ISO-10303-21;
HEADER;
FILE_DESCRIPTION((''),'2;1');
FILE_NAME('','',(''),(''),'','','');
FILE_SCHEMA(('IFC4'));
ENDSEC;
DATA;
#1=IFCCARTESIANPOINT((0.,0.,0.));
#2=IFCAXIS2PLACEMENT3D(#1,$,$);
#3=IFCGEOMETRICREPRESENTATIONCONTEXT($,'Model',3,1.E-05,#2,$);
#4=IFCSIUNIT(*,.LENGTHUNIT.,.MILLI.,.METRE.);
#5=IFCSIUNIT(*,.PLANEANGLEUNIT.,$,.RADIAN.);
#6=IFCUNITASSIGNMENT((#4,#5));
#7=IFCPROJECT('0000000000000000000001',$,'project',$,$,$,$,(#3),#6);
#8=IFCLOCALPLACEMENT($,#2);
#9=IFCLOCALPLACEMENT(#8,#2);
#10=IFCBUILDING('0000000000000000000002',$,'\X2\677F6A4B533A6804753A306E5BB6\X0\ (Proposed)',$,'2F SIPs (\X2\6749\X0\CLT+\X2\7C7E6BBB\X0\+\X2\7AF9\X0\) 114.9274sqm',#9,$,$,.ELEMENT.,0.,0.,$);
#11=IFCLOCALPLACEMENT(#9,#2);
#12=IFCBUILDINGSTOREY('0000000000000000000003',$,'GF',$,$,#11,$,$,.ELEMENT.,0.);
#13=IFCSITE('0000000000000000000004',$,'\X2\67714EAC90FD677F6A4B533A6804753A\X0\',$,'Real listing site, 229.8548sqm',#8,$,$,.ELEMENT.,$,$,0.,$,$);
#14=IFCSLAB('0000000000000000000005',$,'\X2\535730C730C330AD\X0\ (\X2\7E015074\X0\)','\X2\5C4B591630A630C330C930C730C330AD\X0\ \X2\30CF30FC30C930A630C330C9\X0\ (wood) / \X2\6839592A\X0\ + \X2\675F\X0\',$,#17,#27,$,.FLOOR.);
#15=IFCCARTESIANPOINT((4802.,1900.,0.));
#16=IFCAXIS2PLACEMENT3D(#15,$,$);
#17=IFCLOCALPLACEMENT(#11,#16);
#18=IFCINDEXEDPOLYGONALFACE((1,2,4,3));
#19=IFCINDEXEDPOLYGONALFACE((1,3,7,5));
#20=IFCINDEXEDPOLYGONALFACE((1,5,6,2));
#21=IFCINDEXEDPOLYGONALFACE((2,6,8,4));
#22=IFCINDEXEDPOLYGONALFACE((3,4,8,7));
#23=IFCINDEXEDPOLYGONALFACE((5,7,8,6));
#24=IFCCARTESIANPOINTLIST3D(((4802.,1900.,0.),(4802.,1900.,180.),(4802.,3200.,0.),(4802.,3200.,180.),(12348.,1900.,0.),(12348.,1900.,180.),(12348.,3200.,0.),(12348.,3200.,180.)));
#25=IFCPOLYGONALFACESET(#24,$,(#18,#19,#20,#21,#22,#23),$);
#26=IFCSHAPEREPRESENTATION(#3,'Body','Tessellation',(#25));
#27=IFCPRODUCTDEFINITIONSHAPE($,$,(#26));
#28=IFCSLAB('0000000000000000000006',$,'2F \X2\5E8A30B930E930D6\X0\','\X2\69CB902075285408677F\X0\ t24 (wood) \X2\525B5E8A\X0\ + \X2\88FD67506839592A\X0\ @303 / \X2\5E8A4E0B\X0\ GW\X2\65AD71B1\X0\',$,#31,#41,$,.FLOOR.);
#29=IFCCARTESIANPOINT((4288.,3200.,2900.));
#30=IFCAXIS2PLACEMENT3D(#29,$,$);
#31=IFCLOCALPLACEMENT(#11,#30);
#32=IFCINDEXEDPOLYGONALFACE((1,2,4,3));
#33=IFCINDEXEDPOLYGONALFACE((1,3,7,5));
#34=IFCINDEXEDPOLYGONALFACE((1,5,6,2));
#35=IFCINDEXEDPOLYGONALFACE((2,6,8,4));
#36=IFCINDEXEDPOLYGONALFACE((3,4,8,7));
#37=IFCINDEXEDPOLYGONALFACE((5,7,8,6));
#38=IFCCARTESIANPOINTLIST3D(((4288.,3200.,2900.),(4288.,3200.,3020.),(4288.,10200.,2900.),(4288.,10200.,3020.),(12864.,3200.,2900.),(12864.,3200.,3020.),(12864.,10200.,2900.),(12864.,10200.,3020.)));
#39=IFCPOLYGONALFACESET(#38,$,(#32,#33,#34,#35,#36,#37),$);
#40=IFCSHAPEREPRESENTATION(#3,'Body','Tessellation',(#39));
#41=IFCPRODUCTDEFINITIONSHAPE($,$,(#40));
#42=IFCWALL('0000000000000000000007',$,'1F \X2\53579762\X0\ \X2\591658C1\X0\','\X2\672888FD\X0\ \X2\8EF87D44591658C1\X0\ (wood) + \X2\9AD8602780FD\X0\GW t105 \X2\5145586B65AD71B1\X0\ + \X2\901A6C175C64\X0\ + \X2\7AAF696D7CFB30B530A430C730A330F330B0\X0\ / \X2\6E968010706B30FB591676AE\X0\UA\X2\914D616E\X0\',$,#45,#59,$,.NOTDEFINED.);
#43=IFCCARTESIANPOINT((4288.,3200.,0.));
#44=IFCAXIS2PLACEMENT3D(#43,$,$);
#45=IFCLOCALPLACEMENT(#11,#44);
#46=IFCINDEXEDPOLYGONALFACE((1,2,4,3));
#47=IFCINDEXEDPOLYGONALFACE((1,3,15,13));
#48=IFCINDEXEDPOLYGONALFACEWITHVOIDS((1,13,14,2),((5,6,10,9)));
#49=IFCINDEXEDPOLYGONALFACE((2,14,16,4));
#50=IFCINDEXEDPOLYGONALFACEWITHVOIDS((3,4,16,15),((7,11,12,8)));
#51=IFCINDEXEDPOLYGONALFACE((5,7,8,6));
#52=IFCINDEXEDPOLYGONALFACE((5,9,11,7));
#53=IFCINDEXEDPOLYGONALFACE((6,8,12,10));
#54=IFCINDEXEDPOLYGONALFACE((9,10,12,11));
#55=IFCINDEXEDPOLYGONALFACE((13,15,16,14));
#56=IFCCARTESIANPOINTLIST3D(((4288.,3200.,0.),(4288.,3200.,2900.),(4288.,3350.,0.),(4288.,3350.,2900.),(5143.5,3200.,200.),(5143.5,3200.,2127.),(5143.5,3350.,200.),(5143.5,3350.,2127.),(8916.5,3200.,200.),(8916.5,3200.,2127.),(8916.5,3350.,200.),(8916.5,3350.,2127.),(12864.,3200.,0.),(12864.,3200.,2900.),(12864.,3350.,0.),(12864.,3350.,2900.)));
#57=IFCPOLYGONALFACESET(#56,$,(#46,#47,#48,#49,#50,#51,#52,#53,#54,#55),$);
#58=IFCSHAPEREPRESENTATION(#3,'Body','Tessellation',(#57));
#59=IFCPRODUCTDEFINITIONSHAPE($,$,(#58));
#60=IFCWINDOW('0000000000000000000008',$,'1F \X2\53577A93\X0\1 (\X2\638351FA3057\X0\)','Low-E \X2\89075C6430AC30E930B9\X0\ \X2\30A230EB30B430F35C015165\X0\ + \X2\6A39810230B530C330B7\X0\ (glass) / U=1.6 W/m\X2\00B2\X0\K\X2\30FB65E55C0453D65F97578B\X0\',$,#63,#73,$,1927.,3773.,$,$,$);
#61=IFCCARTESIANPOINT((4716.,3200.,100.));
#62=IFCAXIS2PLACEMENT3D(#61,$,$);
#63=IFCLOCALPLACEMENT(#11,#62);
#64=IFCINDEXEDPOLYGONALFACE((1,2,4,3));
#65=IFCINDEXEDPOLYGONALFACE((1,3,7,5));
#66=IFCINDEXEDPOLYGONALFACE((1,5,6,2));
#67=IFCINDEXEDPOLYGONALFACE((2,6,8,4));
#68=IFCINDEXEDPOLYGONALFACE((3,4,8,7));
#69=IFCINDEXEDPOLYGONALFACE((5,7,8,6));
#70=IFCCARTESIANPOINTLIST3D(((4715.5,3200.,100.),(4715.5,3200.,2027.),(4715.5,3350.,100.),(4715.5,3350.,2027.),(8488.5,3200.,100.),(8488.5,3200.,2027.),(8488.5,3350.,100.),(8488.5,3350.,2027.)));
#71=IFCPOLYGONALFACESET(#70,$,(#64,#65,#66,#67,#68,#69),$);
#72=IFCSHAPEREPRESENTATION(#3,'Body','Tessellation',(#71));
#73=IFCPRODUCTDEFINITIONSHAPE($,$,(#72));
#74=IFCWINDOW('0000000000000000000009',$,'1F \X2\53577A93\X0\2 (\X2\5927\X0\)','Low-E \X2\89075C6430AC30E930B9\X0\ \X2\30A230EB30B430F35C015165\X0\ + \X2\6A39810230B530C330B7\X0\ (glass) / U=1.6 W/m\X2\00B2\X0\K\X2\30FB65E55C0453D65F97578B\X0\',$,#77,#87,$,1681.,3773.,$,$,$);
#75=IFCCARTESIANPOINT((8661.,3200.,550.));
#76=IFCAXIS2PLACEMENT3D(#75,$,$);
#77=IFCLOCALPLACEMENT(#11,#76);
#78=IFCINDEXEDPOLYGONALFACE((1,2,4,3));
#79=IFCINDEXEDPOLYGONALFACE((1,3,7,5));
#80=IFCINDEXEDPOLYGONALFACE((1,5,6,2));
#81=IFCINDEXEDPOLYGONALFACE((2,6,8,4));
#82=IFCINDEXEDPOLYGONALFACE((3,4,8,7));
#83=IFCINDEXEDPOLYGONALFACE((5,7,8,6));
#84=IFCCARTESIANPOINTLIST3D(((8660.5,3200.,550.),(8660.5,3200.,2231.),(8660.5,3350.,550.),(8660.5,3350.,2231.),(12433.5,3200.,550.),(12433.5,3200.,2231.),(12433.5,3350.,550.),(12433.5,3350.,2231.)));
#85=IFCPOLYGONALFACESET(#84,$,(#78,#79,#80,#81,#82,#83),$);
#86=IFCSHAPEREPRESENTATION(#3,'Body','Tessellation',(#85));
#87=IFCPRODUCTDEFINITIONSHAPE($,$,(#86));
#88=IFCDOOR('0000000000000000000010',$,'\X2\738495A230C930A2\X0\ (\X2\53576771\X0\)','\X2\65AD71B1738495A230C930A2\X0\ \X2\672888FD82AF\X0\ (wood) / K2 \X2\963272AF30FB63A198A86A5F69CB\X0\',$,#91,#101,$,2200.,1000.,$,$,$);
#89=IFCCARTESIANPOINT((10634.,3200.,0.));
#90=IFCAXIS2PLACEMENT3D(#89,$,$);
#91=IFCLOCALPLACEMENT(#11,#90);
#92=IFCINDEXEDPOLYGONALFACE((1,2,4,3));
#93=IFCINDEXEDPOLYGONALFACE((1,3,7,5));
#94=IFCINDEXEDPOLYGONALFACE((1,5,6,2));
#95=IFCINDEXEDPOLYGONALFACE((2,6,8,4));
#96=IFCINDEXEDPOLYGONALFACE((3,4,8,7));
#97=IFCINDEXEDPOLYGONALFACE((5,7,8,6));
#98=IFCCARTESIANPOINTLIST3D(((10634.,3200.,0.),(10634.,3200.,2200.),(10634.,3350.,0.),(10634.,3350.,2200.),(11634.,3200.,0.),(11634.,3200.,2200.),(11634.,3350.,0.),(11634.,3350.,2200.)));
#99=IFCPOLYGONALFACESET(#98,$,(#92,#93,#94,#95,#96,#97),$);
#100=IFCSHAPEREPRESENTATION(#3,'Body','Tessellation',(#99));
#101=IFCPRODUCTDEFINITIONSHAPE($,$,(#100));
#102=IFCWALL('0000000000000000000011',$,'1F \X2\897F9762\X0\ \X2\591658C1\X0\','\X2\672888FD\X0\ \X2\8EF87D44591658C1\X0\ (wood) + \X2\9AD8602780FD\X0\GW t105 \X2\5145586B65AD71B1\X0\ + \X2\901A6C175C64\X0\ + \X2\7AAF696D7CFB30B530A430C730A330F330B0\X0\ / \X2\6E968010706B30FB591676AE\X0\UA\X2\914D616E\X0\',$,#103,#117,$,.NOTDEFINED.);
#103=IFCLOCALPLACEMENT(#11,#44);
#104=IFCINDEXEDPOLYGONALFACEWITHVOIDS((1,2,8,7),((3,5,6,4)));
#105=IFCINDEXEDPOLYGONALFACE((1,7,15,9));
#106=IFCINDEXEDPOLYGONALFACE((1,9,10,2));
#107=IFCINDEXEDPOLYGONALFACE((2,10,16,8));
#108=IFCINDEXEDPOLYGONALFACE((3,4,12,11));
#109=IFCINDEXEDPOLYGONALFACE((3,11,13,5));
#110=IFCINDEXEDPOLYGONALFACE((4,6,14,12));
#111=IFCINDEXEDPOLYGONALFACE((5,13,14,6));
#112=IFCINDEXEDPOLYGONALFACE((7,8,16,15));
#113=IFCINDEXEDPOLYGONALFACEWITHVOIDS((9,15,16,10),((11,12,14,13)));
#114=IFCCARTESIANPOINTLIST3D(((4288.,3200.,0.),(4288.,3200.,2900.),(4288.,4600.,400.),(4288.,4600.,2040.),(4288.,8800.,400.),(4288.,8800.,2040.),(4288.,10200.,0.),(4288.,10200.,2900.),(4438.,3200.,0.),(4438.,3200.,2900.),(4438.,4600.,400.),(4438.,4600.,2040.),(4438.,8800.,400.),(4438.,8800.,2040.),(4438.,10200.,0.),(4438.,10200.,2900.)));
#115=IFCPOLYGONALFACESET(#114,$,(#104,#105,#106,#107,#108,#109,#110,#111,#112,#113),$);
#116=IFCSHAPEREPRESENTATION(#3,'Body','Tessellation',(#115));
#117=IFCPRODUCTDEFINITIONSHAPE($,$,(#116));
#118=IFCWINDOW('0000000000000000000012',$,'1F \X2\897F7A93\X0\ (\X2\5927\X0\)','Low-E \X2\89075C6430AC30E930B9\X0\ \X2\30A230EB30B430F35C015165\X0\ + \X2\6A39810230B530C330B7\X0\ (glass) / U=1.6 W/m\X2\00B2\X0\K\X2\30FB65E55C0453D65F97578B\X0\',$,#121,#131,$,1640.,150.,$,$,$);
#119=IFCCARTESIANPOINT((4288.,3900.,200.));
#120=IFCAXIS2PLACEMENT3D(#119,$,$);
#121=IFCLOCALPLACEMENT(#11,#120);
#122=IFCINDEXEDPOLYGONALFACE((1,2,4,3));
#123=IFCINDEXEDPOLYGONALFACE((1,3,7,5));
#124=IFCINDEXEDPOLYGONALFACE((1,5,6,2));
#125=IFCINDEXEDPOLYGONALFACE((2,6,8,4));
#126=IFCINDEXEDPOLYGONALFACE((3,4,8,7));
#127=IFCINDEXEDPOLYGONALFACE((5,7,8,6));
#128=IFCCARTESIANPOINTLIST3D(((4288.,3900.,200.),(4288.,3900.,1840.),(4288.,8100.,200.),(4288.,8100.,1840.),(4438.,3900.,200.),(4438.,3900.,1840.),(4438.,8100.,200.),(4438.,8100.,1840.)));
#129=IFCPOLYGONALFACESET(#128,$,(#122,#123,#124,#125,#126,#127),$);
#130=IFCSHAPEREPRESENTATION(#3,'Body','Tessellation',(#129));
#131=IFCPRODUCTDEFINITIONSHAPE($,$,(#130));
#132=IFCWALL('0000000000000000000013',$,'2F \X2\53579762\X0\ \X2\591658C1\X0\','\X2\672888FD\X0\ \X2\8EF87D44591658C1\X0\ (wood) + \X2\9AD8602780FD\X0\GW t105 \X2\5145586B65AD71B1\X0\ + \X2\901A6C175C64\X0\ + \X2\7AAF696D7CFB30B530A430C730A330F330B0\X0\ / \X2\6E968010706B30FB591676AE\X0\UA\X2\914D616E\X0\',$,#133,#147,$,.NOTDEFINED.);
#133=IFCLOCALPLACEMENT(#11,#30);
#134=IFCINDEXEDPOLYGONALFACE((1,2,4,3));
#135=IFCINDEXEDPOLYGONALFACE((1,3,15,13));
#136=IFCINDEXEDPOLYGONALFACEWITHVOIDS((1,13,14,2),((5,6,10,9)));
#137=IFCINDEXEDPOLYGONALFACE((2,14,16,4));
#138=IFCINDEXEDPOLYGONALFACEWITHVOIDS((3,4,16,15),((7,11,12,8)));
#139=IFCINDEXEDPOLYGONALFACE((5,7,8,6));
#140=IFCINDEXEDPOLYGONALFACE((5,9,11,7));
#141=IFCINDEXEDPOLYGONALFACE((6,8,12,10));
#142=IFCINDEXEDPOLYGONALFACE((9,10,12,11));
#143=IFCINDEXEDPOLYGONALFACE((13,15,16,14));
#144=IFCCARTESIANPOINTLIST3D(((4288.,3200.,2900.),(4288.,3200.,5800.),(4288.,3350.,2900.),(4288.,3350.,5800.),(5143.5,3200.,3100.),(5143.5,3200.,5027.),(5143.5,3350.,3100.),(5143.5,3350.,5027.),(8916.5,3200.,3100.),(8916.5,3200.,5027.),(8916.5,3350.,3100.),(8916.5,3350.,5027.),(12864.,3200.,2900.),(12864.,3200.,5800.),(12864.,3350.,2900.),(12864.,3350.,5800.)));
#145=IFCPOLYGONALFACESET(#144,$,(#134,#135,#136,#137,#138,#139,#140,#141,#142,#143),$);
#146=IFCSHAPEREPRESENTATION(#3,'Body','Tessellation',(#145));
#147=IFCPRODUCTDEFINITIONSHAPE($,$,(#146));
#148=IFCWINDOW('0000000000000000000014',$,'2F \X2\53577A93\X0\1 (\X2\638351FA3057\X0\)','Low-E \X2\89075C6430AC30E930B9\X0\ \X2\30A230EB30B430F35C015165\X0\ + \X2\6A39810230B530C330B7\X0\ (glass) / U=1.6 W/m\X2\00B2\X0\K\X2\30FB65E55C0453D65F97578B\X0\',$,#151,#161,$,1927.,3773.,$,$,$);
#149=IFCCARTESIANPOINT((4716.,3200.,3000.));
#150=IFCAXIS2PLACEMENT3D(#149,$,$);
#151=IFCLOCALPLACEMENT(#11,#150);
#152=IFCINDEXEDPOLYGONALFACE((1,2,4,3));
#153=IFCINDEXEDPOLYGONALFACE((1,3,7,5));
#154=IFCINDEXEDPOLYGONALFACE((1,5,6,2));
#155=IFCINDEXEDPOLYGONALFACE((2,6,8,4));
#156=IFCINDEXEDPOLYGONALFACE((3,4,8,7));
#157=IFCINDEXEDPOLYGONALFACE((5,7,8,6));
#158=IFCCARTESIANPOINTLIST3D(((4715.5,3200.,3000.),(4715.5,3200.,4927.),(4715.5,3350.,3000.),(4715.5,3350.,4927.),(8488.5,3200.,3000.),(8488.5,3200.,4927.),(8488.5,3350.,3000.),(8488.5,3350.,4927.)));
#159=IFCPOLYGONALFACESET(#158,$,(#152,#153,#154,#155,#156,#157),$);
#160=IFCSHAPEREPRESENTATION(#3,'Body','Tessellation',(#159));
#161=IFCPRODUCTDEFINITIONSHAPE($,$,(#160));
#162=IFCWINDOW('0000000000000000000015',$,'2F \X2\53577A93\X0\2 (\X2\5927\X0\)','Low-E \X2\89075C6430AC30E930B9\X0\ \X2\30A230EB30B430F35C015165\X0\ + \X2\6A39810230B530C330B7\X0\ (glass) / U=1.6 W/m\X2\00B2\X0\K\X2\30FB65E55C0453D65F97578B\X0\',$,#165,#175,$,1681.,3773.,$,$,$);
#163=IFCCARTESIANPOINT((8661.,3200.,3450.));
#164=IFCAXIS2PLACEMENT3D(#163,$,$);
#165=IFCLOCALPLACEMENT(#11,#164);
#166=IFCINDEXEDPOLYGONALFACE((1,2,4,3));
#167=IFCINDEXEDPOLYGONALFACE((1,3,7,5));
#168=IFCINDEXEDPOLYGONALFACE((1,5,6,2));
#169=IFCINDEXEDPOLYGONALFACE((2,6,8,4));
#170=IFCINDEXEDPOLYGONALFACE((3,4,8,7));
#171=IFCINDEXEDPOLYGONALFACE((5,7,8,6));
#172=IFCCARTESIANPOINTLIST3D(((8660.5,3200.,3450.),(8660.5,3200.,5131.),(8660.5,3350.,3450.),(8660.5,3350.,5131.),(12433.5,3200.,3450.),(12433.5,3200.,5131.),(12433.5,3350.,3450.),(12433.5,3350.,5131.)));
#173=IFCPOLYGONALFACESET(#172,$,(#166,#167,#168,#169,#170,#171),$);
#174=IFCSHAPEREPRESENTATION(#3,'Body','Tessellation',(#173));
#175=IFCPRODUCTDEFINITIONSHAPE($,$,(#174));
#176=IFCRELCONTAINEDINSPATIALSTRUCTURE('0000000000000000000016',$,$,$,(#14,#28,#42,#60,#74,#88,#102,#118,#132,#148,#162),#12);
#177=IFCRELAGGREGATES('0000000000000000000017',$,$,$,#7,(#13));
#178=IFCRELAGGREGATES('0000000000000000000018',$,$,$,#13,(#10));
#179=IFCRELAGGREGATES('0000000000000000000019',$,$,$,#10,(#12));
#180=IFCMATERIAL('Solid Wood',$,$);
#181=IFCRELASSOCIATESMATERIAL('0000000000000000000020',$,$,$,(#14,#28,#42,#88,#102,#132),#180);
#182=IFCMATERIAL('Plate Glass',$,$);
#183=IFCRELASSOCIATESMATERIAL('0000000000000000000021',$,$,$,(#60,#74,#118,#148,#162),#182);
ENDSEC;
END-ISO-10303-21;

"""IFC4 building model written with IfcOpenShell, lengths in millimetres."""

from ifc_helpers import new_model, si_unit, frame, frame_2d, origin, place, context, project, spatial, rectangle, extrude, material, element, fill, save


model = new_model("IFC4")

# Units and contexts
model_context = context("Model", 3, precision=1e-05, world=origin())
ifc_project = project(units=[si_unit("LENGTHUNIT", "METRE", prefix="MILLI"), si_unit("PLANEANGLEUNIT", "RADIAN")], contexts=[model_context])

# Site, building, storey
site_placement = place(None, origin())
site = spatial("IfcSite", under=ifc_project, at=site_placement, Name="東京都板橋区栄町", ObjectType="Real listing site, 229.8548sqm", CompositionType="ELEMENT", RefElevation=0.0)
building_placement = place(site_placement, origin())
building = spatial("IfcBuilding", under=site, at=building_placement, Name="板橋区栄町の家 (Proposed)", ObjectType="2F SIPs (杉CLT+籾殻+竹) 114.9274sqm", CompositionType="ELEMENT", ElevationOfRefHeight=0.0, ElevationOfTerrain=0.0)
storey_placement = place(building_placement, origin())
storey = spatial("IfcBuildingStorey", under=building, at=storey_placement, Name="GF", CompositionType="ELEMENT", Elevation=0.0)

# Slabs
ifc_material_1 = material(Name="Solid Wood")
slab_1_placement = place(storey_placement, frame((4802.0, 1900.0, 0.0)))
element("IfcSlab", 1, at=slab_1_placement, inside=storey, material=ifc_material_1, Name="南デッキ (縁側)", Description="屋外ウッドデッキ ハードウッド (wood) / 根太 + 束", PredefinedType="FLOOR", context=model_context, shape_type="SweptSolid", body=[
    extrude(rectangle(XDim=7546.0, YDim=1300.0, at=frame_2d((3773.0, 650.0))), frame((4802.0, 1900.0, 0.0)), (0.0, 0.0, 1.0), 180.0),
])
slab_2_placement = place(storey_placement, frame((4288.0, 3200.0, 2900.0)))
element("IfcSlab", 2, at=slab_2_placement, inside=storey, material=ifc_material_1, Name="2F 床スラブ", Description="構造用合板 t24 (wood) 剛床 + 製材根太 @303 / 床下 GW断熱", PredefinedType="FLOOR", context=model_context, shape_type="SweptSolid", body=[
    extrude(rectangle(XDim=8576.0, YDim=7000.0, at=frame_2d((4288.0, 3500.0))), frame((4288.0, 3200.0, 2900.0)), (0.0, 0.0, 1.0), 120.0),
])

# Wall, openings, windows, door
wall_1_placement = place(storey_placement, frame((4288.0, 3200.0, 0.0)))
wall_1 = element("IfcWall", 3, at=wall_1_placement, inside=storey, material=ifc_material_1, Name="1F 南面 外壁", Description="木製 軸組外壁 (wood) + 高性能GW t105 充填断熱 + 通気層 + 窯業系サイディング / 準耐火・外皮UA配慮", PredefinedType="NOTDEFINED", context=model_context, shape_type="SweptSolid", body=[
    extrude(rectangle(XDim=8576.0, YDim=150.0, at=frame_2d((4288.0, 75.0))), frame((4288.0, 3200.0, 0.0)), (0.0, 0.0, 1.0), 2900.0),
])
opening_1_placement = place(storey_placement, frame((4716.0, 3200.0, 100.0)))
opening_1 = element("IfcOpeningElement", 4, at=opening_1_placement, cuts=wall_1, PredefinedType="NOTDEFINED", context=model_context, shape_type="SweptSolid", body=[
    extrude(rectangle(XDim=3773.0, YDim=150.0, at=frame_2d((1886.0, 75.0))), frame((4716.0, 3200.0, 100.0)), (0.0, 0.0, 1.0), 1927.0),
])
opening_2_placement = place(storey_placement, frame((8661.0, 3200.0, 550.0)))
opening_2 = element("IfcOpeningElement", 5, at=opening_2_placement, cuts=wall_1, PredefinedType="NOTDEFINED", context=model_context, shape_type="SweptSolid", body=[
    extrude(rectangle(XDim=3773.0, YDim=150.0, at=frame_2d((1886.0, 75.0))), frame((8661.0, 3200.0, 550.0)), (0.0, 0.0, 1.0), 1681.0),
])
opening_3_placement = place(storey_placement, frame((10634.0, 3200.0, 0.0)))
opening_3 = element("IfcOpeningElement", 6, at=opening_3_placement, cuts=wall_1, PredefinedType="NOTDEFINED", context=model_context, shape_type="SweptSolid", body=[
    extrude(rectangle(XDim=1000.0, YDim=150.0, at=frame_2d((500.0, 75.0))), frame((10634.0, 3200.0, 0.0)), (0.0, 0.0, 1.0), 2200.0),
])
ifc_material_2 = material(Name="Plate Glass")
window_1_placement = place(storey_placement, frame((4716.0, 3200.0, 100.0)))
window_1 = element("IfcWindow", 7, at=window_1_placement, inside=storey, material=ifc_material_2, Name="1F 南窓1 (掃出し)", Description="Low-E 複層ガラス アルゴン封入 + 樹脂サッシ (glass) / U=1.6 W/m²K・日射取得型", OverallHeight=1927.0, OverallWidth=3773.0, context=model_context, shape_type="SweptSolid", body=[
    extrude(rectangle(XDim=3773.0, YDim=150.0, at=frame_2d((1886.0, 75.0))), frame((4716.0, 3200.0, 100.0)), (0.0, 0.0, 1.0), 1927.0),
])
fill(opening_1, window_1)
window_2_placement = place(storey_placement, frame((8661.0, 3200.0, 550.0)))
window_2 = element("IfcWindow", 8, at=window_2_placement, inside=storey, material=ifc_material_2, Name="1F 南窓2 (大)", Description="Low-E 複層ガラス アルゴン封入 + 樹脂サッシ (glass) / U=1.6 W/m²K・日射取得型", OverallHeight=1681.0, OverallWidth=3773.0, context=model_context, shape_type="SweptSolid", body=[
    extrude(rectangle(XDim=3773.0, YDim=150.0, at=frame_2d((1886.0, 75.0))), frame((8661.0, 3200.0, 550.0)), (0.0, 0.0, 1.0), 1681.0),
])
fill(opening_2, window_2)
door_placement = place(storey_placement, frame((10634.0, 3200.0, 0.0)))
door = element("IfcDoor", 9, at=door_placement, inside=storey, material=ifc_material_1, Name="玄関ドア (南東)", Description="断熱玄関ドア 木製芯 (wood) / K2 防犯・採風機構", OverallHeight=2200.0, OverallWidth=1000.0, context=model_context, shape_type="SweptSolid", body=[
    extrude(rectangle(XDim=1000.0, YDim=150.0, at=frame_2d((500.0, 75.0))), frame((10634.0, 3200.0, 0.0)), (0.0, 0.0, 1.0), 2200.0),
])
fill(opening_3, door)

# Wall, opening, window
wall_2_placement = place(storey_placement, frame((4288.0, 3200.0, 0.0)))
wall_2 = element("IfcWall", 10, at=wall_2_placement, inside=storey, material=ifc_material_1, Name="1F 西面 外壁", Description="木製 軸組外壁 (wood) + 高性能GW t105 充填断熱 + 通気層 + 窯業系サイディング / 準耐火・外皮UA配慮", PredefinedType="NOTDEFINED", context=model_context, shape_type="SweptSolid", body=[
    extrude(rectangle(XDim=150.0, YDim=7000.0, at=frame_2d((75.0, 3500.0))), frame((4288.0, 3200.0, 0.0)), (0.0, 0.0, 1.0), 2900.0),
])
opening_4_placement = place(storey_placement, frame((4288.0, 3900.0, 200.0)))
opening_4 = element("IfcOpeningElement", 11, at=opening_4_placement, cuts=wall_2, PredefinedType="NOTDEFINED", context=model_context, shape_type="SweptSolid", body=[
    extrude(rectangle(XDim=150.0, YDim=4200.0, at=frame_2d((75.0, 2100.0))), frame((4288.0, 3900.0, 200.0)), (0.0, 0.0, 1.0), 1640.0),
])
window_3_placement = place(storey_placement, frame((4288.0, 3900.0, 200.0)))
window_3 = element("IfcWindow", 12, at=window_3_placement, inside=storey, material=ifc_material_2, Name="1F 西窓 (大)", Description="Low-E 複層ガラス アルゴン封入 + 樹脂サッシ (glass) / U=1.6 W/m²K・日射取得型", OverallHeight=1640.0, OverallWidth=150.0, context=model_context, shape_type="SweptSolid", body=[
    extrude(rectangle(XDim=150.0, YDim=4200.0, at=frame_2d((75.0, 2100.0))), frame((4288.0, 3900.0, 200.0)), (0.0, 0.0, 1.0), 1640.0),
])
fill(opening_4, window_3)

# Wall, openings, windows
wall_3_placement = place(storey_placement, frame((4288.0, 3200.0, 2900.0)))
wall_3 = element("IfcWall", 13, at=wall_3_placement, inside=storey, material=ifc_material_1, Name="2F 南面 外壁", Description="木製 軸組外壁 (wood) + 高性能GW t105 充填断熱 + 通気層 + 窯業系サイディング / 準耐火・外皮UA配慮", PredefinedType="NOTDEFINED", context=model_context, shape_type="SweptSolid", body=[
    extrude(rectangle(XDim=8576.0, YDim=150.0, at=frame_2d((4288.0, 75.0))), frame((4288.0, 3200.0, 2900.0)), (0.0, 0.0, 1.0), 2900.0),
])
opening_5_placement = place(storey_placement, frame((4716.0, 3200.0, 3000.0)))
opening_5 = element("IfcOpeningElement", 14, at=opening_5_placement, cuts=wall_3, PredefinedType="NOTDEFINED", context=model_context, shape_type="SweptSolid", body=[
    extrude(rectangle(XDim=3773.0, YDim=150.0, at=frame_2d((1886.0, 75.0))), frame((4716.0, 3200.0, 3000.0)), (0.0, 0.0, 1.0), 1927.0),
])
opening_6_placement = place(storey_placement, frame((8661.0, 3200.0, 3450.0)))
opening_6 = element("IfcOpeningElement", 15, at=opening_6_placement, cuts=wall_3, PredefinedType="NOTDEFINED", context=model_context, shape_type="SweptSolid", body=[
    extrude(rectangle(XDim=3773.0, YDim=150.0, at=frame_2d((1886.0, 75.0))), frame((8661.0, 3200.0, 3450.0)), (0.0, 0.0, 1.0), 1681.0),
])
window_4_placement = place(storey_placement, frame((4716.0, 3200.0, 3000.0)))
window_4 = element("IfcWindow", 16, at=window_4_placement, inside=storey, material=ifc_material_2, Name="2F 南窓1 (掃出し)", Description="Low-E 複層ガラス アルゴン封入 + 樹脂サッシ (glass) / U=1.6 W/m²K・日射取得型", OverallHeight=1927.0, OverallWidth=3773.0, context=model_context, shape_type="SweptSolid", body=[
    extrude(rectangle(XDim=3773.0, YDim=150.0, at=frame_2d((1886.0, 75.0))), frame((4716.0, 3200.0, 3000.0)), (0.0, 0.0, 1.0), 1927.0),
])
fill(opening_5, window_4)
window_5_placement = place(storey_placement, frame((8661.0, 3200.0, 3450.0)))
window_5 = element("IfcWindow", 17, at=window_5_placement, inside=storey, material=ifc_material_2, Name="2F 南窓2 (大)", Description="Low-E 複層ガラス アルゴン封入 + 樹脂サッシ (glass) / U=1.6 W/m²K・日射取得型", OverallHeight=1681.0, OverallWidth=3773.0, context=model_context, shape_type="SweptSolid", body=[
    extrude(rectangle(XDim=3773.0, YDim=150.0, at=frame_2d((1886.0, 75.0))), frame((8661.0, 3200.0, 3450.0)), (0.0, 0.0, 1.0), 1681.0),
])
fill(opening_6, window_5)

save(model, "model.ifc")
